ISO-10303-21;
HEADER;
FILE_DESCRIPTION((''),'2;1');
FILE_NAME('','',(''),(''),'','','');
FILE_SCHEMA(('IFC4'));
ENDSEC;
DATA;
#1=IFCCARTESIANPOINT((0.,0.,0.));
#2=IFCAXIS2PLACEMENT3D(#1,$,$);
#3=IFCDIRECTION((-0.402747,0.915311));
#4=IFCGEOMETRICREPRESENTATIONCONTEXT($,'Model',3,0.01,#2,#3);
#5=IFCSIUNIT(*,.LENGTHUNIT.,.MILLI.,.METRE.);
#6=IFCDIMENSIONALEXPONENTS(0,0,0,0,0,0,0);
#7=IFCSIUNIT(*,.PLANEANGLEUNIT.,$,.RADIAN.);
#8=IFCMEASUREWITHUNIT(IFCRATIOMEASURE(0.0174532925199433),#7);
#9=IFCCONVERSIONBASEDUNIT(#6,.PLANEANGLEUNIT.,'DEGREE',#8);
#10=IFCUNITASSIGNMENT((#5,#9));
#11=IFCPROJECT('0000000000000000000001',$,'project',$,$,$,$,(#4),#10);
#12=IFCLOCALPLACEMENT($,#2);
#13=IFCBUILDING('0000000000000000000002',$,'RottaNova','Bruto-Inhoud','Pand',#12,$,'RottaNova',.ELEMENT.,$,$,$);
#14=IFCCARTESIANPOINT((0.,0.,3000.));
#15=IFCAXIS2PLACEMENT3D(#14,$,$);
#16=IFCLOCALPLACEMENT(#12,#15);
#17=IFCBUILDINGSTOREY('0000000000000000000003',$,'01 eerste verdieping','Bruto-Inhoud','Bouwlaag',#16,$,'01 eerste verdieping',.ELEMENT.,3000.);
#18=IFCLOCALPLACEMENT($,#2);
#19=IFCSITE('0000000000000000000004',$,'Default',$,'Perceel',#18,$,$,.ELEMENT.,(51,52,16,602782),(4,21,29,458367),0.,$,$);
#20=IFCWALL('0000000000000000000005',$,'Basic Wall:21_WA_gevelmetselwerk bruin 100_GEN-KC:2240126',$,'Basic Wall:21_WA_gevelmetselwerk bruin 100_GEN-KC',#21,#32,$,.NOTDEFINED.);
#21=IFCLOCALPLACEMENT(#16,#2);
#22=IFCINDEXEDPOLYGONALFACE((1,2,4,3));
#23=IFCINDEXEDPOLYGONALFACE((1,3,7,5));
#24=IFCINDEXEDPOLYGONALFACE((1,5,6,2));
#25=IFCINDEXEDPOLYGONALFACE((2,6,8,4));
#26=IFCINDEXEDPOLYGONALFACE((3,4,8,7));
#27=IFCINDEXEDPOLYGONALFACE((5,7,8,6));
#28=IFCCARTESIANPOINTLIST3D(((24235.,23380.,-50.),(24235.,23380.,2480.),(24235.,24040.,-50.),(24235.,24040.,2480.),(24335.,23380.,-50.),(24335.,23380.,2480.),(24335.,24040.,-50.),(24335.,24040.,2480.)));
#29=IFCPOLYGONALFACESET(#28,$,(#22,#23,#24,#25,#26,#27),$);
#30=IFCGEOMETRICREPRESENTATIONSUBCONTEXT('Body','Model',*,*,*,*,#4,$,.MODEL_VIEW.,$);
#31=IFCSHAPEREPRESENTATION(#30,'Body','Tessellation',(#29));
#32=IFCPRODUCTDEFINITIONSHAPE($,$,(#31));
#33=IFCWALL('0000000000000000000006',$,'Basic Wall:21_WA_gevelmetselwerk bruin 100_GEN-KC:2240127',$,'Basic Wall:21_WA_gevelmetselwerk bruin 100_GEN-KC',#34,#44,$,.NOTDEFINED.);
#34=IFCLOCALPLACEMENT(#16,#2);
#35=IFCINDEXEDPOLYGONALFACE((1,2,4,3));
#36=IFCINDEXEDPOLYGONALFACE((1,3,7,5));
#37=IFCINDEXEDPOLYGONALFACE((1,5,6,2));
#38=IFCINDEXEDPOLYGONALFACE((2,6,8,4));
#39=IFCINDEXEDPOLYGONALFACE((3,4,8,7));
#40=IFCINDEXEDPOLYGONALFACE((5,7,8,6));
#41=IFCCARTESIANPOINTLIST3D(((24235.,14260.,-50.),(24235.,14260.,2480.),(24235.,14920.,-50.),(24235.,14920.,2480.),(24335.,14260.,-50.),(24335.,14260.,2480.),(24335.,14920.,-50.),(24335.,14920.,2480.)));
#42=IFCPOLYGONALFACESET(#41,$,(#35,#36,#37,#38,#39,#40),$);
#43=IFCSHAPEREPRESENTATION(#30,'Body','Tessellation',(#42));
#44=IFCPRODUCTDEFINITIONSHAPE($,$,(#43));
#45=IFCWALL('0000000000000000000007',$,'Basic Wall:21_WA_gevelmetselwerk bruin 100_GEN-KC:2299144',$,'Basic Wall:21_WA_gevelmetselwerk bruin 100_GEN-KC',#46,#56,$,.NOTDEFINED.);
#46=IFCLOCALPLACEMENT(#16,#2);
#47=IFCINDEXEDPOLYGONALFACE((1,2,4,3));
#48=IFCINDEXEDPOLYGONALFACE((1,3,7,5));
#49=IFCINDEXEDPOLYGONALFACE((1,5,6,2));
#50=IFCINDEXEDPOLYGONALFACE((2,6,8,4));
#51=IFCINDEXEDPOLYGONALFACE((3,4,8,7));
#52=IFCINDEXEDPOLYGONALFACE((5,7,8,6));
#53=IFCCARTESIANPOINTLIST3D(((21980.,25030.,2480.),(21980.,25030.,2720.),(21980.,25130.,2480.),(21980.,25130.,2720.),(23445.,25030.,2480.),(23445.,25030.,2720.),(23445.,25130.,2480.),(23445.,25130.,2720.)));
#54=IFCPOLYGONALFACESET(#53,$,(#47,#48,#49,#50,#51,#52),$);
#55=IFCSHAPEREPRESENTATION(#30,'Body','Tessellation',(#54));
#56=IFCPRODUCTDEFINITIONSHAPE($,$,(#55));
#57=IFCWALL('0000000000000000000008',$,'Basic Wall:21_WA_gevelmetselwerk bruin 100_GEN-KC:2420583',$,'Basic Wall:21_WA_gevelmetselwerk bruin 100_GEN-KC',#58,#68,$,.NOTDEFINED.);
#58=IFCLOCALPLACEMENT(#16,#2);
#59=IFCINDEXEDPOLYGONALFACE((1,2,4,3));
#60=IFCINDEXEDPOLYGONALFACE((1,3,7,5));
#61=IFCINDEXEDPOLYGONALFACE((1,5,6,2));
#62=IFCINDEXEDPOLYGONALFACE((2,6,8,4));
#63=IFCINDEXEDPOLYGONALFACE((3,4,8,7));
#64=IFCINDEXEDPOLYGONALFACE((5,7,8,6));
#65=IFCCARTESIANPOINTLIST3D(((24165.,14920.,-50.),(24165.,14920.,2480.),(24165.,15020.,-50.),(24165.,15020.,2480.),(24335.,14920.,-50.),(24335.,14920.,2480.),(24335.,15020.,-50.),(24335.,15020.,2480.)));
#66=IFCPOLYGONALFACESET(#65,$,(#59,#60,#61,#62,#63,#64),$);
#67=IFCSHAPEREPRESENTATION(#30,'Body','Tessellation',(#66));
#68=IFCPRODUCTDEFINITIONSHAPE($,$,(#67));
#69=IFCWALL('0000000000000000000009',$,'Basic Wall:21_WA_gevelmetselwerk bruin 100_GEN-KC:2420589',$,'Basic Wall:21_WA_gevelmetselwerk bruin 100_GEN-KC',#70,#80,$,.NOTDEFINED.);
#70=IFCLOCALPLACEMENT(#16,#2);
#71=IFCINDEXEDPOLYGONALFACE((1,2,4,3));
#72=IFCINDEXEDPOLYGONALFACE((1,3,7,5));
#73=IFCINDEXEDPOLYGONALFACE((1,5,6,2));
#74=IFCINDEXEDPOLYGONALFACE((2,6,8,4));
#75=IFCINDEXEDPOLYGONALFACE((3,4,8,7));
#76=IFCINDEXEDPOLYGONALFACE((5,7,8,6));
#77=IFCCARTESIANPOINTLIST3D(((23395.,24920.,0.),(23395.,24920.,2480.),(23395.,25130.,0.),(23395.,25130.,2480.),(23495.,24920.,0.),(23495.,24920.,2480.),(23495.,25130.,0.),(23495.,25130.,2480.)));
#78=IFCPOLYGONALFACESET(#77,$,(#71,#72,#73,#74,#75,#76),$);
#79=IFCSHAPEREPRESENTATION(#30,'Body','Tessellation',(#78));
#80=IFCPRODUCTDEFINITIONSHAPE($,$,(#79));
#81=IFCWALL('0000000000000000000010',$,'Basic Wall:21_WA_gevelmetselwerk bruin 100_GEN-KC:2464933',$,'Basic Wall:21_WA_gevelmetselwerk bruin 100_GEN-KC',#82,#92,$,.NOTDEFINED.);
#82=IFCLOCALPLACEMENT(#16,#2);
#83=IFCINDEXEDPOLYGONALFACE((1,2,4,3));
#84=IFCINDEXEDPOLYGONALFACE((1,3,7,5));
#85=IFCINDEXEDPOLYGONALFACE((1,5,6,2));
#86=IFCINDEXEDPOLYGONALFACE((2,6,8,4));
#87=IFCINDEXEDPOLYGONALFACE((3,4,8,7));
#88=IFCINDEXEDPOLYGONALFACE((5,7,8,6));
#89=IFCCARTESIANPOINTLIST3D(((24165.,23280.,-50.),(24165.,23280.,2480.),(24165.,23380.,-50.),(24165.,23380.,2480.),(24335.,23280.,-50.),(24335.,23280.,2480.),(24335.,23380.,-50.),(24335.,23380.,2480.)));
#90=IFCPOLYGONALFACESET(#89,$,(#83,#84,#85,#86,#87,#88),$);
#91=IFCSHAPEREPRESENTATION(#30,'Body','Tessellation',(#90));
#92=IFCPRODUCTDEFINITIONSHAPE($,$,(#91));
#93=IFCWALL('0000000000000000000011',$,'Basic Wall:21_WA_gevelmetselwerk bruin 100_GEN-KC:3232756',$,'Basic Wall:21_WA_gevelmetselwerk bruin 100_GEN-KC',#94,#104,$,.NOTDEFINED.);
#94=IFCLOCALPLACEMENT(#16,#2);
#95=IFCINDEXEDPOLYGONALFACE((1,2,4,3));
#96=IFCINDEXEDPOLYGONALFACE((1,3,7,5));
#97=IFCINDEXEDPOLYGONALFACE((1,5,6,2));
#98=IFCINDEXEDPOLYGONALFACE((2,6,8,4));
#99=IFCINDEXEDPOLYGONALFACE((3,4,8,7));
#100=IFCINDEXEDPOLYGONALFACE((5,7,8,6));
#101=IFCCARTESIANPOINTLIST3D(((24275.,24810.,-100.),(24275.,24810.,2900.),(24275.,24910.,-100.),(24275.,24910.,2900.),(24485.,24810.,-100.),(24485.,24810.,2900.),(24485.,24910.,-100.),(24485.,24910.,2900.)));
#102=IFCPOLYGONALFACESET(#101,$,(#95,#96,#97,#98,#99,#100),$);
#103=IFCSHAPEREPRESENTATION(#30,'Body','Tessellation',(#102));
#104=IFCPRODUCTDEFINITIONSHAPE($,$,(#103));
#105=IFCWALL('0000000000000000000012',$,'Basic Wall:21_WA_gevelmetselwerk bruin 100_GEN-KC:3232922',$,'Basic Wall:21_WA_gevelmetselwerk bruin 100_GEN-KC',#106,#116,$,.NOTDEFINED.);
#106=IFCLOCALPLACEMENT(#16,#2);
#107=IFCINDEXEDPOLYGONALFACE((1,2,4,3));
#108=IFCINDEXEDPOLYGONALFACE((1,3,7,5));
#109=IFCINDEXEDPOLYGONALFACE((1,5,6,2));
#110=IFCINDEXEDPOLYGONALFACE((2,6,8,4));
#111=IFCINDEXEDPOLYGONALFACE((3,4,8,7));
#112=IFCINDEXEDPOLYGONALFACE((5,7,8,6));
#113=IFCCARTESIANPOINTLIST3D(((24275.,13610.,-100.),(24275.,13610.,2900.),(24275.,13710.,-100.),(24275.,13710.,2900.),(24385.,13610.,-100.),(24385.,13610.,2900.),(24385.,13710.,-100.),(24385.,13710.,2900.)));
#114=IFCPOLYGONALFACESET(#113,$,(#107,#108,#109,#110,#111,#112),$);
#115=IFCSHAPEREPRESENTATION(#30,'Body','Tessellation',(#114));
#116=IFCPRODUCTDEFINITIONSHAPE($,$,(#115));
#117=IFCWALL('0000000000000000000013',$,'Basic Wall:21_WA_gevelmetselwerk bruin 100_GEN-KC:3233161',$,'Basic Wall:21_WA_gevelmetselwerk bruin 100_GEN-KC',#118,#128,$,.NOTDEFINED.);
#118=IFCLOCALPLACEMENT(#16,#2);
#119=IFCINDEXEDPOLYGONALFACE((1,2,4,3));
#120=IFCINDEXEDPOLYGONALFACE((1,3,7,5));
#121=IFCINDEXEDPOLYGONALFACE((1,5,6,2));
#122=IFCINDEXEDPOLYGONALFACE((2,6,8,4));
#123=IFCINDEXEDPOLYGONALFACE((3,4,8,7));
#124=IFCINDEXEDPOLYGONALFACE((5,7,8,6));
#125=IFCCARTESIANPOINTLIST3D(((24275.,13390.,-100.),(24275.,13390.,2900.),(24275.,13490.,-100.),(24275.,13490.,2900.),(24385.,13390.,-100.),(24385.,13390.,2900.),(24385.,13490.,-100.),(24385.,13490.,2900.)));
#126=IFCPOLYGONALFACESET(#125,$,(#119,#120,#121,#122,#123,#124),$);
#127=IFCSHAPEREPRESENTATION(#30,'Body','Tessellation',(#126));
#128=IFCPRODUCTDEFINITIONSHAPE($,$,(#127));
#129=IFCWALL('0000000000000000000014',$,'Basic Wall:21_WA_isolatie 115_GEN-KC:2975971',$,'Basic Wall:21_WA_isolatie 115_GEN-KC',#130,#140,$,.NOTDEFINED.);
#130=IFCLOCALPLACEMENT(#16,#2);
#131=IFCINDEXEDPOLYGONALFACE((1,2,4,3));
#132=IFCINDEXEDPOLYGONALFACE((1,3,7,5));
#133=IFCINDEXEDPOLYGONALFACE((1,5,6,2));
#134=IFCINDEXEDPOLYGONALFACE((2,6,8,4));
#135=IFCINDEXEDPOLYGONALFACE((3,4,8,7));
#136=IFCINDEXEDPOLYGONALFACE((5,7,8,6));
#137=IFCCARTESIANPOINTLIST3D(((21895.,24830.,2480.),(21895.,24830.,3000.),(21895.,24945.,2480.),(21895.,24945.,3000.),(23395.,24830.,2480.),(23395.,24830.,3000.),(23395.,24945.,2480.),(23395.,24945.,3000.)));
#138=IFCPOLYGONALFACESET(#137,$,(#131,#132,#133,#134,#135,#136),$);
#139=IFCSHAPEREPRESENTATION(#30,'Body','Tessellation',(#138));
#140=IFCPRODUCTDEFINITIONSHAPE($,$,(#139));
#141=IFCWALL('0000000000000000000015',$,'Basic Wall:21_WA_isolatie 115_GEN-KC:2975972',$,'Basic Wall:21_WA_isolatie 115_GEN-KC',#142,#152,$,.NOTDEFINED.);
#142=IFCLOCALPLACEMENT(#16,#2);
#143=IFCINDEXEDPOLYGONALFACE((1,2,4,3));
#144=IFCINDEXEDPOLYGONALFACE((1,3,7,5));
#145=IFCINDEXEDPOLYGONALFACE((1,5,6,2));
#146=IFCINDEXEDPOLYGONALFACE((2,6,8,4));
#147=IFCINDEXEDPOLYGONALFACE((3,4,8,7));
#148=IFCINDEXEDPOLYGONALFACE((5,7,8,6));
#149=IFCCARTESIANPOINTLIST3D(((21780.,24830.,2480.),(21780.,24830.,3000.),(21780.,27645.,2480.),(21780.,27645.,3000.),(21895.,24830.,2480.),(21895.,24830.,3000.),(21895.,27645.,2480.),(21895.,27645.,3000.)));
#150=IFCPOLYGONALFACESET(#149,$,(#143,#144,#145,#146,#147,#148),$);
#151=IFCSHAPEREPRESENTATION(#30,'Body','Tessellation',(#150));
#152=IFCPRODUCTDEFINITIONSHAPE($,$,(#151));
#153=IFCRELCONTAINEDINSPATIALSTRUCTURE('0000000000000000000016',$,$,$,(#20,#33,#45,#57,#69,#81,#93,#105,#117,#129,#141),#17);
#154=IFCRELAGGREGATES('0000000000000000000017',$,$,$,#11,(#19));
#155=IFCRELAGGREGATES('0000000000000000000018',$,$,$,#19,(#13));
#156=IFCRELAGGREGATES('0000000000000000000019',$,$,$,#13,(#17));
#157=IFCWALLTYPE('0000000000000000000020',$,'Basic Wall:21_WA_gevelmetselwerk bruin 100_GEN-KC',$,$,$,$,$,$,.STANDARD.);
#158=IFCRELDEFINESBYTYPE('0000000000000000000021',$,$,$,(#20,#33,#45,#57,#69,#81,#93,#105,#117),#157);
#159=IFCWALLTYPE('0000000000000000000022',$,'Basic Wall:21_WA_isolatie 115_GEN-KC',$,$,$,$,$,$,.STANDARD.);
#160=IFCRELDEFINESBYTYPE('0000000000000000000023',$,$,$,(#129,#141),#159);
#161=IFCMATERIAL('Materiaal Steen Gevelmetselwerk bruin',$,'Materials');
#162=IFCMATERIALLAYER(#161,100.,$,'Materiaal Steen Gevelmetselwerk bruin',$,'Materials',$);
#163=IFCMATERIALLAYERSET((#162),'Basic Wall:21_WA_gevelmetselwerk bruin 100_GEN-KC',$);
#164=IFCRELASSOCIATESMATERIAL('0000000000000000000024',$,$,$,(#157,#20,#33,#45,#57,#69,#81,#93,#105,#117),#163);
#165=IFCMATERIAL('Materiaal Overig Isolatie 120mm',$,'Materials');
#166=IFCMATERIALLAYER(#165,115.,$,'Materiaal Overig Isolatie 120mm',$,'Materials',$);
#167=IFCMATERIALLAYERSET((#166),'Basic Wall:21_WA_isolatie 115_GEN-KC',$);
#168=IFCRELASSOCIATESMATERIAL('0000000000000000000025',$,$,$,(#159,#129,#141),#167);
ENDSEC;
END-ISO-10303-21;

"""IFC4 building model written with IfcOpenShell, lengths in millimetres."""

from ifc_helpers import new_model, entity, si_unit, converted_unit, direction, frame, frame_2d, origin, place, context, subcontext, project, spatial, rectangle, extrude, material, layer, layer_set, type_object, element, save


model = new_model("IFC4")

# Units and contexts
model_context = context("Model", 3, precision=0.01, world=origin(), true_north=direction((-0.402747, 0.915311)))
body_context = subcontext(model_context, "Body", "Model", "MODEL_VIEW")
ifc_project = project(units=[si_unit("LENGTHUNIT", "METRE", prefix="MILLI"), converted_unit("PLANEANGLEUNIT", "DEGREE", entity("IfcRatioMeasure", 0.0174532925199433), si_unit("PLANEANGLEUNIT", "RADIAN"), dimensions=[0, 0, 0, 0, 0, 0, 0])], contexts=[model_context])

# Site, building, storey
site_placement = place(None, origin())
site = spatial("IfcSite", under=ifc_project, at=site_placement, Name="Default", ObjectType="Perceel", CompositionType="ELEMENT", RefLatitude=(51, 52, 16, 602782), RefLongitude=(4, 21, 29, 458367), RefElevation=0.0)
building_placement = place(None, origin())
building = spatial("IfcBuilding", under=site, at=building_placement, Name="RottaNova", Description="Bruto-Inhoud", ObjectType="Pand", LongName="RottaNova", CompositionType="ELEMENT")
storey_placement = place(building_placement, frame((0.0, 0.0, 3000.0)))
storey = spatial("IfcBuildingStorey", under=building, at=storey_placement, Name="01 eerste verdieping", Description="Bruto-Inhoud", ObjectType="Bouwlaag", LongName="01 eerste verdieping", CompositionType="ELEMENT", Elevation=3000.0)

# Walls
ifc_material_1 = material(Name="Materiaal Steen Gevelmetselwerk bruin", Category="Materials")
ifc_layer_1 = layer(ifc_material_1, 100.0, Name="Materiaal Steen Gevelmetselwerk bruin", Category="Materials")
ifc_layer_set_1 = layer_set([ifc_layer_1], Name="Basic Wall:21_WA_gevelmetselwerk bruin 100_GEN-KC")
wall_type_1 = type_object("IfcWallType", Name="Basic Wall:21_WA_gevelmetselwerk bruin 100_GEN-KC", PredefinedType="STANDARD", material=ifc_layer_set_1)
wall_1_placement = place(storey_placement, frame((24285.0, 24040.0, -50.0), z_axis=(0.0, 0.0, 1.0), x_axis=(0.0, -1.0, 0.0)))
element("IfcWall", 1, at=wall_1_placement, inside=storey, type_object=wall_type_1, material=ifc_layer_set_1, Name="Basic Wall:21_WA_gevelmetselwerk bruin 100_GEN-KC:2240126", ObjectType="Basic Wall:21_WA_gevelmetselwerk bruin 100_GEN-KC", PredefinedType="NOTDEFINED", context=body_context, shape_type="SweptSolid", body=[
    extrude(rectangle(XDim=660.0, YDim=100.0, at=frame_2d((330.0, 0.0), x_axis=(-1.0, 0.0))), origin(), (0.0, 0.0, 1.0), 2530.0),
])
wall_2_placement = place(storey_placement, frame((24285.0, 14260.0, -50.0), z_axis=(0.0, 0.0, 1.0), x_axis=(0.0, 1.0, 0.0)))
element("IfcWall", 2, at=wall_2_placement, inside=storey, type_object=wall_type_1, material=ifc_layer_set_1, Name="Basic Wall:21_WA_gevelmetselwerk bruin 100_GEN-KC:2240127", ObjectType="Basic Wall:21_WA_gevelmetselwerk bruin 100_GEN-KC", PredefinedType="NOTDEFINED", context=body_context, shape_type="SweptSolid", body=[
    extrude(rectangle(XDim=660.0, YDim=100.0, at=frame_2d((330.0, 0.0), x_axis=(-1.0, 0.0))), origin(), (0.0, 0.0, 1.0), 2530.0),
])
wall_3_placement = place(storey_placement, frame((23445.0, 25080.0, 2480.0), z_axis=(0.0, 0.0, 1.0), x_axis=(-1.0, 0.0, 0.0)))
element("IfcWall", 3, at=wall_3_placement, inside=storey, type_object=wall_type_1, material=ifc_layer_set_1, Name="Basic Wall:21_WA_gevelmetselwerk bruin 100_GEN-KC:2299144", ObjectType="Basic Wall:21_WA_gevelmetselwerk bruin 100_GEN-KC", PredefinedType="NOTDEFINED", context=body_context, shape_type="SweptSolid", body=[
    extrude(rectangle(XDim=1465.0, YDim=100.0, at=frame_2d((732.5, 0.0), x_axis=(-1.0, 0.0))), origin(), (0.0, 0.0, 1.0), 240.0),
])
wall_4_placement = place(storey_placement, frame((24335.0, 14970.0, -50.0), z_axis=(0.0, 0.0, 1.0), x_axis=(-1.0, 0.0, 0.0)))
element("IfcWall", 4, at=wall_4_placement, inside=storey, type_object=wall_type_1, material=ifc_layer_set_1, Name="Basic Wall:21_WA_gevelmetselwerk bruin 100_GEN-KC:2420583", ObjectType="Basic Wall:21_WA_gevelmetselwerk bruin 100_GEN-KC", PredefinedType="NOTDEFINED", context=body_context, shape_type="SweptSolid", body=[
    extrude(rectangle(XDim=170.0, YDim=100.0, at=frame_2d((85.0, 0.0), x_axis=(-1.0, 0.0))), origin(), (0.0, 0.0, 1.0), 2530.0),
])
wall_5_placement = place(storey_placement, frame((23445.0, 24920.0, 0.0), z_axis=(0.0, 0.0, 1.0), x_axis=(0.0, 1.0, 0.0)))
element("IfcWall", 5, at=wall_5_placement, inside=storey, type_object=wall_type_1, material=ifc_layer_set_1, Name="Basic Wall:21_WA_gevelmetselwerk bruin 100_GEN-KC:2420589", ObjectType="Basic Wall:21_WA_gevelmetselwerk bruin 100_GEN-KC", PredefinedType="NOTDEFINED", context=body_context, shape_type="SweptSolid", body=[
    extrude(rectangle(XDim=210.0, YDim=100.0, at=frame_2d((105.0, 0.0), x_axis=(-1.0, 0.0))), origin(), (0.0, 0.0, 1.0), 2480.0),
])
wall_6_placement = place(storey_placement, frame((24335.0, 23330.0, -50.0), z_axis=(0.0, 0.0, 1.0), x_axis=(-1.0, 0.0, 0.0)))
element("IfcWall", 6, at=wall_6_placement, inside=storey, type_object=wall_type_1, material=ifc_layer_set_1, Name="Basic Wall:21_WA_gevelmetselwerk bruin 100_GEN-KC:2464933", ObjectType="Basic Wall:21_WA_gevelmetselwerk bruin 100_GEN-KC", PredefinedType="NOTDEFINED", context=body_context, shape_type="SweptSolid", body=[
    extrude(rectangle(XDim=170.0, YDim=100.0, at=frame_2d((85.0, 0.0), x_axis=(-1.0, 0.0))), origin(), (0.0, 0.0, 1.0), 2530.0),
])
wall_7_placement = place(storey_placement, frame((24485.0, 24860.0, -100.0), z_axis=(0.0, 0.0, 1.0), x_axis=(-1.0, 0.0, 0.0)))
element("IfcWall", 7, at=wall_7_placement, inside=storey, type_object=wall_type_1, material=ifc_layer_set_1, Name="Basic Wall:21_WA_gevelmetselwerk bruin 100_GEN-KC:3232756", ObjectType="Basic Wall:21_WA_gevelmetselwerk bruin 100_GEN-KC", PredefinedType="NOTDEFINED", context=body_context, shape_type="SweptSolid", body=[
    extrude(rectangle(XDim=210.0, YDim=100.0, at=frame_2d((105.0, 0.0), x_axis=(-1.0, 0.0))), origin(), (0.0, 0.0, 1.0), 3000.0),
])
wall_8_placement = place(storey_placement, frame((24275.0, 13660.0, -100.0)))
element("IfcWall", 8, at=wall_8_placement, inside=storey, type_object=wall_type_1, material=ifc_layer_set_1, Name="Basic Wall:21_WA_gevelmetselwerk bruin 100_GEN-KC:3232922", ObjectType="Basic Wall:21_WA_gevelmetselwerk bruin 100_GEN-KC", PredefinedType="NOTDEFINED", context=body_context, shape_type="SweptSolid", body=[
    extrude(rectangle(XDim=110.0, YDim=100.0, at=frame_2d((55.0, 0.0), x_axis=(-1.0, 0.0))), origin(), (0.0, 0.0, 1.0), 3000.0),
])
wall_9_placement = place(storey_placement, frame((24275.0, 13440.0, -100.0)))
element("IfcWall", 9, at=wall_9_placement, inside=storey, type_object=wall_type_1, material=ifc_layer_set_1, Name="Basic Wall:21_WA_gevelmetselwerk bruin 100_GEN-KC:3233161", ObjectType="Basic Wall:21_WA_gevelmetselwerk bruin 100_GEN-KC", PredefinedType="NOTDEFINED", context=body_context, shape_type="SweptSolid", body=[
    extrude(rectangle(XDim=110.0, YDim=100.0, at=frame_2d((55.0, 0.0), x_axis=(-1.0, 0.0))), origin(), (0.0, 0.0, 1.0), 3000.0),
])
ifc_material_2 = material(Name="Materiaal Overig Isolatie 120mm", Category="Materials")
ifc_layer_2 = layer(ifc_material_2, 115.0, Name="Materiaal Overig Isolatie 120mm", Category="Materials")
ifc_layer_set_2 = layer_set([ifc_layer_2], Name="Basic Wall:21_WA_isolatie 115_GEN-KC")
wall_type_2 = type_object("IfcWallType", Name="Basic Wall:21_WA_isolatie 115_GEN-KC", PredefinedType="STANDARD", material=ifc_layer_set_2)
wall_10_placement = place(storey_placement, frame((23395.0, 24887.5, 2480.0), z_axis=(0.0, 0.0, 1.0), x_axis=(-1.0, 0.0, 0.0)))
element("IfcWall", 10, at=wall_10_placement, inside=storey, type_object=wall_type_2, material=ifc_layer_set_2, Name="Basic Wall:21_WA_isolatie 115_GEN-KC:2975971", ObjectType="Basic Wall:21_WA_isolatie 115_GEN-KC", PredefinedType="NOTDEFINED", context=body_context, shape_type="SweptSolid", body=[
    extrude(rectangle(XDim=1500.0, YDim=115.0, at=frame_2d((750.0, 0.0), x_axis=(1.0, 0.0))), origin(), (0.0, 0.0, 1.0), 520.0),
])
wall_11_placement = place(storey_placement, frame((21837.5, 24830.0, 2480.0), z_axis=(0.0, 0.0, 1.0), x_axis=(0.0, 1.0, 0.0)))
element("IfcWall", 11, at=wall_11_placement, inside=storey, type_object=wall_type_2, material=ifc_layer_set_2, Name="Basic Wall:21_WA_isolatie 115_GEN-KC:2975972", ObjectType="Basic Wall:21_WA_isolatie 115_GEN-KC", PredefinedType="NOTDEFINED", context=body_context, shape_type="SweptSolid", body=[
    extrude(rectangle(XDim=2815.0, YDim=115.0, at=frame_2d((1407.5, 0.0), x_axis=(-1.0, 0.0))), origin(), (0.0, 0.0, 1.0), 520.0),
])

save(model, "model.ifc")
